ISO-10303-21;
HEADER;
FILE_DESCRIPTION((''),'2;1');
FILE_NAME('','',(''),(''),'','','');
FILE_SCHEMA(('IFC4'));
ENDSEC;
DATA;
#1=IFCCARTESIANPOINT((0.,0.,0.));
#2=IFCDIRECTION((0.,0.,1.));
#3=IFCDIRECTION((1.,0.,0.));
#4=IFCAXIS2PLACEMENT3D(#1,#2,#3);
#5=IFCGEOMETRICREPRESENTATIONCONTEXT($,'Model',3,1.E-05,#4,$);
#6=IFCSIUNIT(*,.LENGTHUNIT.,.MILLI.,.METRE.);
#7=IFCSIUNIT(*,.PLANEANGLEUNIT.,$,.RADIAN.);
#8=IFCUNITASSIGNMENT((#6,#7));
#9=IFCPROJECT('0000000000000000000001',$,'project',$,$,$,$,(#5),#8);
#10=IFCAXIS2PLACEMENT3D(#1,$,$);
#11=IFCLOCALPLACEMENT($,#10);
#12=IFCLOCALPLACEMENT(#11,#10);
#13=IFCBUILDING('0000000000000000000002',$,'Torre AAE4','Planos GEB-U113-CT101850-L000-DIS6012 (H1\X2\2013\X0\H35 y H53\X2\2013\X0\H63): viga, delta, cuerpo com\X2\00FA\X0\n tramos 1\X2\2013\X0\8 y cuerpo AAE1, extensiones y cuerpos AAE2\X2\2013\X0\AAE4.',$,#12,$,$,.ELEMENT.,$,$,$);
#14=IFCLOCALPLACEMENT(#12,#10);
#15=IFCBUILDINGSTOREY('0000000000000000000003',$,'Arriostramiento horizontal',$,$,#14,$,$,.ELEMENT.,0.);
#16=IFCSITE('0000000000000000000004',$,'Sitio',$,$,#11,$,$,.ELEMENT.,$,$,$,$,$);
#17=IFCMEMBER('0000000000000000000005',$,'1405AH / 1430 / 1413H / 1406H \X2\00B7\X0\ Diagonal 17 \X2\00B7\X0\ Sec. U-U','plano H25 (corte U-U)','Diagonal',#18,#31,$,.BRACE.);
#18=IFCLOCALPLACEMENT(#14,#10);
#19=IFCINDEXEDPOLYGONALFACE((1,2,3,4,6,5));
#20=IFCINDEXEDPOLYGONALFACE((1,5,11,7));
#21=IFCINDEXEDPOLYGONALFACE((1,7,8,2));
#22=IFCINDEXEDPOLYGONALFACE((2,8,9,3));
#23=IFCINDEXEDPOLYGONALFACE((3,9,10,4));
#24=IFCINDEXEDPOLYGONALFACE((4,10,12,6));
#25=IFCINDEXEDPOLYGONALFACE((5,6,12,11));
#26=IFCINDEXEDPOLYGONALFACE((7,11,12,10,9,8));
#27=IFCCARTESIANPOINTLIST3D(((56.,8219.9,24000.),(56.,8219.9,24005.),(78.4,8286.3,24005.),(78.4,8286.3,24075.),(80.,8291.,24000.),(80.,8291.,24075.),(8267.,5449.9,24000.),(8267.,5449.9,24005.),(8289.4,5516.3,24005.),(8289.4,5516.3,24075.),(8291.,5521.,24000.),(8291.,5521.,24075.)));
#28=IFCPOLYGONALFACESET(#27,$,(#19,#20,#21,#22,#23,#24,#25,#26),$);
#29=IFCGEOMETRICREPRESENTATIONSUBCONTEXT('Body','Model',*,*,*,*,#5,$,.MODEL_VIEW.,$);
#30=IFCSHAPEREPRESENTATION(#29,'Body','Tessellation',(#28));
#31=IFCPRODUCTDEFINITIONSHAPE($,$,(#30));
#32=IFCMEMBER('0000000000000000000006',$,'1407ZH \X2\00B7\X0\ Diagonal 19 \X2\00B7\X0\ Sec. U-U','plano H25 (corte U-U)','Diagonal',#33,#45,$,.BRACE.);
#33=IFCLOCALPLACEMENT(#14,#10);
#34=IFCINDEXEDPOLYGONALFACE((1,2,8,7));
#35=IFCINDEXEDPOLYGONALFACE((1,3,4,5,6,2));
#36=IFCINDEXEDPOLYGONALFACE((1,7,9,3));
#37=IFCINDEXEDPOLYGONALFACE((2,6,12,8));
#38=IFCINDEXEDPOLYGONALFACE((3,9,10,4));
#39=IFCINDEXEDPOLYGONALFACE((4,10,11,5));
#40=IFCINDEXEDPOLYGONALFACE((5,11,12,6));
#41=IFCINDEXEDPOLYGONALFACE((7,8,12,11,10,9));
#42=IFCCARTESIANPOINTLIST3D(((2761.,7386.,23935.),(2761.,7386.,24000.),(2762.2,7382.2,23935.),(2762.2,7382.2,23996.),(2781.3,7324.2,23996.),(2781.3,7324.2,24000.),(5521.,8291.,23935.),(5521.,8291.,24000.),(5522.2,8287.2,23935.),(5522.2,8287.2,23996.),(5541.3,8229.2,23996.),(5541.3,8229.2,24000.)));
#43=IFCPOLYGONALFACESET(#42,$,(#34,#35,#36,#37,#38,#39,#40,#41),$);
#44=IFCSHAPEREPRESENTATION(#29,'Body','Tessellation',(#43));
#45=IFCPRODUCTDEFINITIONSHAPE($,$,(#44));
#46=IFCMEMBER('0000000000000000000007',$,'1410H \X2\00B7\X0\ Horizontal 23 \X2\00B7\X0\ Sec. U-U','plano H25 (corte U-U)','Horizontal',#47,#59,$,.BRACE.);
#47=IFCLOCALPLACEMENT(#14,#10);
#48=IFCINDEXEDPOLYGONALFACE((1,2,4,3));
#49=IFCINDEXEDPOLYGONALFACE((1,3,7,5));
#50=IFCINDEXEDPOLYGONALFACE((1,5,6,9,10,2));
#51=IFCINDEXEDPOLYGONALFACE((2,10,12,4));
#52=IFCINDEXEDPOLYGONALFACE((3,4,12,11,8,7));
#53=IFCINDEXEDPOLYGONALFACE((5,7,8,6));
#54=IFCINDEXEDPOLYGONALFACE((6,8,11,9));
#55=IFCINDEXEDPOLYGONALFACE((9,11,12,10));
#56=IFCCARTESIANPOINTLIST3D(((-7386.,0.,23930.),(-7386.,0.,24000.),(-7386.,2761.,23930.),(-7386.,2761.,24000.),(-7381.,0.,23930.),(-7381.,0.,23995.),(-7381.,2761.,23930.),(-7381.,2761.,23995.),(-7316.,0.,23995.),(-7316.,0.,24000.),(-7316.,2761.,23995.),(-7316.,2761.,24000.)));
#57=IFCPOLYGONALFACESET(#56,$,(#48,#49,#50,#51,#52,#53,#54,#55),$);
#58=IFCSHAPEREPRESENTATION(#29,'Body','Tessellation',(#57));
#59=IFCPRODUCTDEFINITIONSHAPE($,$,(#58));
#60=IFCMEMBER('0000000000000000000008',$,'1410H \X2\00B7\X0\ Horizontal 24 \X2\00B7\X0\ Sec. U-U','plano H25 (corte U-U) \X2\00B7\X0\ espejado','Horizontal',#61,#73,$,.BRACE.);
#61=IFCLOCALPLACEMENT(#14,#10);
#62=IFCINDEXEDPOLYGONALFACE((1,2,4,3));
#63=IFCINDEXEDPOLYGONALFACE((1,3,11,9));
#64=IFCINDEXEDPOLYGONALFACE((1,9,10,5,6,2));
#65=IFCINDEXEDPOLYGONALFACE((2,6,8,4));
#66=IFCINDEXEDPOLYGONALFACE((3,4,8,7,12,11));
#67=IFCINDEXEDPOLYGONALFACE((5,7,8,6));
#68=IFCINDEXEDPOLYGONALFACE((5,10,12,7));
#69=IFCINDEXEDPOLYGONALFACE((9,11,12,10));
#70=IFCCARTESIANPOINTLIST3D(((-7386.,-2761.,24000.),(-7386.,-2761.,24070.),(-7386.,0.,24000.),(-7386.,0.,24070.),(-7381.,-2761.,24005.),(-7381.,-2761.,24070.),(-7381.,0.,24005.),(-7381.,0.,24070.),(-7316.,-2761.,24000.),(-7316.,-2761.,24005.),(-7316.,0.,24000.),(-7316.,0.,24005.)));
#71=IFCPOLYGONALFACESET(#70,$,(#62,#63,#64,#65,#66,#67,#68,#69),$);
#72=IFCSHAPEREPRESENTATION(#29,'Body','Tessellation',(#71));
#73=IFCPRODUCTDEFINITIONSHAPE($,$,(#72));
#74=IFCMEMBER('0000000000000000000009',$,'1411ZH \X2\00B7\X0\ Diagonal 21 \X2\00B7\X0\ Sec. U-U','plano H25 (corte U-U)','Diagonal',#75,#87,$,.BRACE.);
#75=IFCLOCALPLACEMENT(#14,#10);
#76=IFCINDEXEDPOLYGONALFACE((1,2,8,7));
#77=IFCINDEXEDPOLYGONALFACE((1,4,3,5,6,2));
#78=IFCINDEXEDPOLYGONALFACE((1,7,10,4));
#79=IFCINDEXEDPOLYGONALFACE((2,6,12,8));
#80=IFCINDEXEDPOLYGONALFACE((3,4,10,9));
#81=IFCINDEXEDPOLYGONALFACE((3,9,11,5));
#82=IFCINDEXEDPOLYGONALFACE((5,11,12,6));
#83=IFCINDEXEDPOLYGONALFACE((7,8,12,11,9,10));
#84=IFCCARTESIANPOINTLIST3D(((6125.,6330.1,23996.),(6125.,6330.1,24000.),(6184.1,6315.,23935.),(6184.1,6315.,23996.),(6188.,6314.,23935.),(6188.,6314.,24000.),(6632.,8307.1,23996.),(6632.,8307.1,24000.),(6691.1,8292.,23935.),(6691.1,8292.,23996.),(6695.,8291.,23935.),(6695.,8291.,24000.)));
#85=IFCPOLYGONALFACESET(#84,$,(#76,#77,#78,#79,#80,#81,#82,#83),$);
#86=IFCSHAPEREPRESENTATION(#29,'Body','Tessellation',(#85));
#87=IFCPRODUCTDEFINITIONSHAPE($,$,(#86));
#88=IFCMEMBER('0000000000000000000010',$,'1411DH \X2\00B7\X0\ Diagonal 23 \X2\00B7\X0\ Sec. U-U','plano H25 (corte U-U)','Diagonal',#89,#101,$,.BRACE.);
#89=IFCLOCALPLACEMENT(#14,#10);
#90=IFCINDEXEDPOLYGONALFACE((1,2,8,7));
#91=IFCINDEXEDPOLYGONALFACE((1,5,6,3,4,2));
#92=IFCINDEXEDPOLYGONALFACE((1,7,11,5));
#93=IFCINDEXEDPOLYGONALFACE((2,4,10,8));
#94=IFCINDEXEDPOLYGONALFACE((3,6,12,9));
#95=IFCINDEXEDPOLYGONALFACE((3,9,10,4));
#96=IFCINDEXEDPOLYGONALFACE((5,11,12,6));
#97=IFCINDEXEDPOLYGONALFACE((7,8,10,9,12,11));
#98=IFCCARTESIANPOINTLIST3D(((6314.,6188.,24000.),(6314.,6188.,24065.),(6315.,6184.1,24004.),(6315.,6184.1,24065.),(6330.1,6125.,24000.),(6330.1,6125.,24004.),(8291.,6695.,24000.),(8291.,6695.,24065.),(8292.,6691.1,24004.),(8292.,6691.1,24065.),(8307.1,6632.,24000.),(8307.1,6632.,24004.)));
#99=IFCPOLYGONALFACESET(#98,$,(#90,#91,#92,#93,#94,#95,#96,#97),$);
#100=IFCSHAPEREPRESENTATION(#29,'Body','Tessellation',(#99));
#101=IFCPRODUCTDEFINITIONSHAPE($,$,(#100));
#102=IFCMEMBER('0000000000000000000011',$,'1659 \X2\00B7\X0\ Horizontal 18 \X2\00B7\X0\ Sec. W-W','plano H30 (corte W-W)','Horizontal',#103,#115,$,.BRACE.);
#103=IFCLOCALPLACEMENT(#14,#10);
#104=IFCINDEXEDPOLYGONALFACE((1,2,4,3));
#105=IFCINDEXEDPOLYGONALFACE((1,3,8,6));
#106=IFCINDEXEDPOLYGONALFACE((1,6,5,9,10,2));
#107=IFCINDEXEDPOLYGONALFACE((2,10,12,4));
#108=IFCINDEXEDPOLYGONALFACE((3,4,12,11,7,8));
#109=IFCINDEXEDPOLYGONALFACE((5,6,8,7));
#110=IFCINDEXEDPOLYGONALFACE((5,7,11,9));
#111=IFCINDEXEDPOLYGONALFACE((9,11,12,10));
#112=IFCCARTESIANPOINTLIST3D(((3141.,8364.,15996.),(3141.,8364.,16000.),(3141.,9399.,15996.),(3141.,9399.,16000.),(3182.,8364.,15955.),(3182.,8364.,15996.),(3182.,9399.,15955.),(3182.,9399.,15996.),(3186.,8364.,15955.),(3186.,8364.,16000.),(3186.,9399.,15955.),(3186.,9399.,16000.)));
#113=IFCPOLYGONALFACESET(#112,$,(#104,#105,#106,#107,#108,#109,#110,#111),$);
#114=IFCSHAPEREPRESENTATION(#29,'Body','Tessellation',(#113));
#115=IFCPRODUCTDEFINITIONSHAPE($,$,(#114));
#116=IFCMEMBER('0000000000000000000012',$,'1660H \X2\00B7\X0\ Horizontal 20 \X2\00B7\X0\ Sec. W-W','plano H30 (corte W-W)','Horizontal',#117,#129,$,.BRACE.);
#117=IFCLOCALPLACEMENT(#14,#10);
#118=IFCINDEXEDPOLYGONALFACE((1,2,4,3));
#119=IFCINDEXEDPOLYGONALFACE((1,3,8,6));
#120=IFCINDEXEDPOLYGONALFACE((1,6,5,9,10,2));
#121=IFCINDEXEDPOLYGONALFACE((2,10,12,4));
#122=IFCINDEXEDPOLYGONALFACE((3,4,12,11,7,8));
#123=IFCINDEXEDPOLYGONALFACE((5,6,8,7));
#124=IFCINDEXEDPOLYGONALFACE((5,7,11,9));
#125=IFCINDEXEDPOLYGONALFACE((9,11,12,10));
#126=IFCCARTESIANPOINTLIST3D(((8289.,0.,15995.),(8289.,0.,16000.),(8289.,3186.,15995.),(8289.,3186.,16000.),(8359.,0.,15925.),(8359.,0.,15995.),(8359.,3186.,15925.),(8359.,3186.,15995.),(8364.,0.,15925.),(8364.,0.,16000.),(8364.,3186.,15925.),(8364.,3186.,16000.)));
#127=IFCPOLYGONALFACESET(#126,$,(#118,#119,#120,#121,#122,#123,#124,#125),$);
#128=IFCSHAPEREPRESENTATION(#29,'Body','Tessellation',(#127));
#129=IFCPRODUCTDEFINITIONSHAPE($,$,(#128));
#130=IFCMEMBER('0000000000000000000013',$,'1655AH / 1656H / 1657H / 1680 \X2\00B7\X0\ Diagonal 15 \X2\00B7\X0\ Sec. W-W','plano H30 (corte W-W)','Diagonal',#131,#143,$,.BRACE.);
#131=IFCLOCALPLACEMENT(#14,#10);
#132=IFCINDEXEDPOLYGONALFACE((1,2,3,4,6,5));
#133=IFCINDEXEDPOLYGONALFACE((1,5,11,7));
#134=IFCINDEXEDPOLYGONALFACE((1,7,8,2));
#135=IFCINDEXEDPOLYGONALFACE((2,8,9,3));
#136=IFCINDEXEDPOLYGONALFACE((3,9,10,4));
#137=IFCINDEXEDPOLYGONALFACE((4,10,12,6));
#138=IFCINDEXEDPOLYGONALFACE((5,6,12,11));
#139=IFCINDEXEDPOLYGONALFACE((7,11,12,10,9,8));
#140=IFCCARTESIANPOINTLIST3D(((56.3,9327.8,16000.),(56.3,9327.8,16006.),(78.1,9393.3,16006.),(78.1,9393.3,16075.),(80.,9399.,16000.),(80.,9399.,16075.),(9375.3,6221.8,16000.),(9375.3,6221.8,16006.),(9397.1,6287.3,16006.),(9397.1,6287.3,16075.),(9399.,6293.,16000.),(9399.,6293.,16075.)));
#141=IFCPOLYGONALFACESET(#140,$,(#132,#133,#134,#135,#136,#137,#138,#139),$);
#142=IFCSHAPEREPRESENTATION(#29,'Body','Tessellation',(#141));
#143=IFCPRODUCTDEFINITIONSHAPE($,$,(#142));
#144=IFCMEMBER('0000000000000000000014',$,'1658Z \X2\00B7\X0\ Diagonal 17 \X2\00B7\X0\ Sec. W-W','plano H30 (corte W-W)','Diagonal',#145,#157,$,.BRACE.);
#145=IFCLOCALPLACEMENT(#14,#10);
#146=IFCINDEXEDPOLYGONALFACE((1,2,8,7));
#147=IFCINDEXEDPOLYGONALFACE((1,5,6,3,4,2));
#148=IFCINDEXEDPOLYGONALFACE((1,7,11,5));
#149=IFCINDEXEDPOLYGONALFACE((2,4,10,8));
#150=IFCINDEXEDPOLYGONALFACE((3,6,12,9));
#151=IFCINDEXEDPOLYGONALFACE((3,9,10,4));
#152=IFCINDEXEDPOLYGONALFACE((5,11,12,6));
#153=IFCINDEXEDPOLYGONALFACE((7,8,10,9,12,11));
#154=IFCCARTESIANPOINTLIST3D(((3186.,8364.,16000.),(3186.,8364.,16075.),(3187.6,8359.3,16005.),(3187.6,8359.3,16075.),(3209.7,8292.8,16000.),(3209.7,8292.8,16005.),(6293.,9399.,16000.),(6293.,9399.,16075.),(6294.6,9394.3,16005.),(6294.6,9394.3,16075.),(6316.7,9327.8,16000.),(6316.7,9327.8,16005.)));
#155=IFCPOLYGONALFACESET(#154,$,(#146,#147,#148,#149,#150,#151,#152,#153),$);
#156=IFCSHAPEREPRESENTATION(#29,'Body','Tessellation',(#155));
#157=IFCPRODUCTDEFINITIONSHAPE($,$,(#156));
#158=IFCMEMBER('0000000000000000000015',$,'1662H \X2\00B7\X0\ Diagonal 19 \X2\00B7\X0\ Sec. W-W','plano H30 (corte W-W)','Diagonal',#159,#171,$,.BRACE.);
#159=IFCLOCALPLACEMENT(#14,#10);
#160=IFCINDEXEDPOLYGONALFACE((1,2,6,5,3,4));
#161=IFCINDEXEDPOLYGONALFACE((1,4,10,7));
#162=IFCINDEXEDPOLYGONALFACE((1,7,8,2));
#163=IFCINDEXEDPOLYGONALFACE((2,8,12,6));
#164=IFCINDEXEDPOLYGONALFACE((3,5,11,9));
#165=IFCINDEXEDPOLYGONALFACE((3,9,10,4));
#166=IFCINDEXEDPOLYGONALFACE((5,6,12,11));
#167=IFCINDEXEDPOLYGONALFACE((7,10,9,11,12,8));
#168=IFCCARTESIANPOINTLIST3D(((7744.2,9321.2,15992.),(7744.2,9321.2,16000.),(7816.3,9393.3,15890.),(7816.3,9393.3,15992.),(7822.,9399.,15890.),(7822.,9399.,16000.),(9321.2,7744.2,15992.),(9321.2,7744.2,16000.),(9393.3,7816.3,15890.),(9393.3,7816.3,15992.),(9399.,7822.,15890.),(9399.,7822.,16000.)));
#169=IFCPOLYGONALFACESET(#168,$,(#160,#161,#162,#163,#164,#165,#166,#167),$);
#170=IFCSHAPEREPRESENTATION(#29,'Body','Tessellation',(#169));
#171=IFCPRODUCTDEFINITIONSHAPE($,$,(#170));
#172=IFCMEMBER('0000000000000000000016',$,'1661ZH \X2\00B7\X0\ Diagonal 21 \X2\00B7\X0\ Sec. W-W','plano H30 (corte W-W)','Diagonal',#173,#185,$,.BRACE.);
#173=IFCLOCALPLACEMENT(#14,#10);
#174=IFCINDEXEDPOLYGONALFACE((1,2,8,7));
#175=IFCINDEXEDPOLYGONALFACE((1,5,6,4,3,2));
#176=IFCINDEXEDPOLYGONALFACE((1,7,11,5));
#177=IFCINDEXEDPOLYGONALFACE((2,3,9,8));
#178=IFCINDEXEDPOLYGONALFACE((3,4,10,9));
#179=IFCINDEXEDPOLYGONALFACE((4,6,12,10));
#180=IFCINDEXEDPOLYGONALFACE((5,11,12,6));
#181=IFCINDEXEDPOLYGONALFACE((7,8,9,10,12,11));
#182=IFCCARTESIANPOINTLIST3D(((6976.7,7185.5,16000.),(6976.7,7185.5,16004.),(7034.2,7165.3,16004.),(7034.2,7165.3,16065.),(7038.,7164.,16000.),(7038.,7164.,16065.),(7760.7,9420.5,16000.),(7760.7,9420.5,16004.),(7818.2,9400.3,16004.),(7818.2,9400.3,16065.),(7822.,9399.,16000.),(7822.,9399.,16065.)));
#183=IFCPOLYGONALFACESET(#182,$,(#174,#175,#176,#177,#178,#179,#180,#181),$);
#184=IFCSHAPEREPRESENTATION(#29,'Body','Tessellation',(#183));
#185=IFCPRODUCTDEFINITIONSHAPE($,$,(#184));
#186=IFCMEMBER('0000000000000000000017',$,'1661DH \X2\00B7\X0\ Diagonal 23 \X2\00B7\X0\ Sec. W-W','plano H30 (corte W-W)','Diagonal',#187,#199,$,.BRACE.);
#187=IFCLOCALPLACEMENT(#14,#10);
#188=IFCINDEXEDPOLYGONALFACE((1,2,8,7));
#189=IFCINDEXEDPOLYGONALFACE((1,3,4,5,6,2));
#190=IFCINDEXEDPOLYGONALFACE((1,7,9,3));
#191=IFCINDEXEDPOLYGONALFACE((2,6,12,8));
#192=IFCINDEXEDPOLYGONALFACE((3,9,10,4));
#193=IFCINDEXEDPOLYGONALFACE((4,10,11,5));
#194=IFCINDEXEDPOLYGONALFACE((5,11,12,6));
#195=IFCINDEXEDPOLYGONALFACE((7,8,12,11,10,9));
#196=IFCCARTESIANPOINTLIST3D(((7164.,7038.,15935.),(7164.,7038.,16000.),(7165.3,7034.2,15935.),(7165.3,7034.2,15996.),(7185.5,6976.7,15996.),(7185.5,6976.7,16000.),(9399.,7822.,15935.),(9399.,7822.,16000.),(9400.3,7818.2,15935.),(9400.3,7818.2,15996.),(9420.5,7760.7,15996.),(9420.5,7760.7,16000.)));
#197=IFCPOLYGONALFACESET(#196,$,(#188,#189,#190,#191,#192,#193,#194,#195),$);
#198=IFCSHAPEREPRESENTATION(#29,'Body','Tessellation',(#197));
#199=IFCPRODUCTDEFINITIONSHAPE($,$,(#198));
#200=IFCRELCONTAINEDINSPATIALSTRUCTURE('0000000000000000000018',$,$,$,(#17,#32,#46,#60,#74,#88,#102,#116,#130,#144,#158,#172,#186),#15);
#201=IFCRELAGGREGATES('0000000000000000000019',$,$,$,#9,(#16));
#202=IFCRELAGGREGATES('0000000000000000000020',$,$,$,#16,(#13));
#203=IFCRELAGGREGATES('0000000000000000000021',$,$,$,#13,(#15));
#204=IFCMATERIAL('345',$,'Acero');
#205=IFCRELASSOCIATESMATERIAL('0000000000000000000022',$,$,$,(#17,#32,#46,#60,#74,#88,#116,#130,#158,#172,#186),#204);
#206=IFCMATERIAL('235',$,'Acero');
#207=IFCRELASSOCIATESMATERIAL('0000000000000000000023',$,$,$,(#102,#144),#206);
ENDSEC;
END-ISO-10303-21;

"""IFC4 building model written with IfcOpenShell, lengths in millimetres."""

from ifc_helpers import new_model, si_unit, frame, frame_2d, origin, origin_with_axes, place, context, subcontext, project, spatial, l_section, extrude, material, element, save


model = new_model("IFC4")

# Units and contexts
model_context = context("Model", 3, precision=1e-05, world=origin_with_axes())
body_context = subcontext(model_context, "Body", "Model", "MODEL_VIEW")
ifc_project = project(units=[si_unit("LENGTHUNIT", "METRE", prefix="MILLI"), si_unit("PLANEANGLEUNIT", "RADIAN")], contexts=[model_context])

# Site, building, storey
site_placement = place(None, origin())
site = spatial("IfcSite", under=ifc_project, at=site_placement, Name="Sitio", CompositionType="ELEMENT")
building_placement = place(site_placement, origin())
building = spatial("IfcBuilding", under=site, at=building_placement, Name="Torre AAE4", Description="Planos GEB-U113-CT101850-L000-DIS6012 (H1–H35 y H53–H63): viga, delta, cuerpo común tramos 1–8 y cuerpo AAE1, extensiones y cuerpos AAE2–AAE4.", CompositionType="ELEMENT")
storey_placement = place(building_placement, origin())
storey = spatial("IfcBuildingStorey", under=building, at=storey_placement, Name="Arriostramiento horizontal", CompositionType="ELEMENT", Elevation=0.0)

# Members
ifc_material_1 = material(Name="235", Category="Acero")
ifc_material_2 = material(Name="345", Category="Acero")
member_1_placement = place(storey_placement, frame((8291.0, 5521.0, 24000.0), z_axis=(-0.947535, 0.319653, 0.0), x_axis=(-0.319653, -0.947535, 0.0)))
element("IfcMember", 1, at=member_1_placement, inside=storey, material=ifc_material_2, Name="1405AH / 1430 / 1413H / 1406H · Diagonal 17 · Sec. U-U", Description="plano H25 (corte U-U)", ObjectType="Diagonal", PredefinedType="BRACE", context=body_context, shape_type="SweptSolid", body=[
    extrude(l_section(Depth=75.0, Width=75.0, Thickness=5.0, at=frame_2d((37.5, 37.5))), None, (0.0, 0.0, 1.0), 8665.6),
])
member_2_placement = place(storey_placement, frame((2761.0, 7386.0, 24000.0), z_axis=(0.950221, 0.311576, 0.0), x_axis=(0.311576, -0.950221, 0.0)))
element("IfcMember", 2, at=member_2_placement, inside=storey, material=ifc_material_2, Name="1407ZH · Diagonal 19 · Sec. U-U", Description="plano H25 (corte U-U)", ObjectType="Diagonal", PredefinedType="BRACE", context=body_context, shape_type="SweptSolid", body=[
    extrude(l_section(Depth=65.0, Width=65.0, Thickness=4.0, at=frame_2d((32.5, 32.5))), None, (0.0, 0.0, 1.0), 2904.6),
])
for number, where, z_axis, x_axis, name, description in (
    (3, (-7386.0, 0.0, 24000.0), (0.0, 1.0, 0.0), (1.0, 0.0, 0.0), "1410H · Horizontal 23 · Sec. U-U", "plano H25 (corte U-U)"),
    (4, (-7386.0, 0.0, 24000.0), (0.0, -1.0, 0.0), (1.0, 0.0, 0.0), "1410H · Horizontal 24 · Sec. U-U", "plano H25 (corte U-U) · espejado"),
):
    element("IfcMember", number, at=place(storey_placement, frame(where, z_axis=z_axis, x_axis=x_axis)), inside=storey, material=ifc_material_2, Name=name, Description=description, ObjectType="Horizontal", PredefinedType="BRACE", context=body_context, shape_type="SweptSolid", body=[
        extrude(l_section(Depth=70.0, Width=70.0, Thickness=5.0, at=frame_2d((35.0, 35.0))), None, (0.0, 0.0, 1.0), 2761.0),
    ])
for number, where, z_axis, x_axis, name in (
    (5, (6695.0, 8291.0, 24000.0), (-0.248411, -0.968655, 0.0), (-0.968655, 0.248411, 0.0), "1411ZH · Diagonal 21 · Sec. U-U"),
    (6, (8291.0, 6695.0, 24000.0), (-0.968655, -0.248411, 0.0), (0.248411, -0.968655, 0.0), "1411DH · Diagonal 23 · Sec. U-U"),
):
    element("IfcMember", number, at=place(storey_placement, frame(where, z_axis=z_axis, x_axis=x_axis)), inside=storey, material=ifc_material_2, Name=name, Description="plano H25 (corte U-U)", ObjectType="Diagonal", PredefinedType="BRACE", context=body_context, shape_type="SweptSolid", body=[
        extrude(l_section(Depth=65.0, Width=65.0, Thickness=4.0, at=frame_2d((32.5, 32.5))), None, (0.0, 0.0, 1.0), 2041.0),
    ])
member_3_placement = place(storey_placement, frame((3186.0, 9399.0, 16000.0), z_axis=(0.0, -1.0, 0.0), x_axis=(-1.0, 0.0, 0.0)))
element("IfcMember", 7, at=member_3_placement, inside=storey, material=ifc_material_1, Name="1659 · Horizontal 18 · Sec. W-W", Description="plano H30 (corte W-W)", ObjectType="Horizontal", PredefinedType="BRACE", context=body_context, shape_type="SweptSolid", body=[
    extrude(l_section(Depth=45.0, Width=45.0, Thickness=4.0, at=frame_2d((22.5, 22.5))), None, (0.0, 0.0, 1.0), 1035.0),
])
member_4_placement = place(storey_placement, frame((8364.0, 3186.0, 16000.0), z_axis=(0.0, -1.0, 0.0), x_axis=(-1.0, 0.0, 0.0)))
element("IfcMember", 8, at=member_4_placement, inside=storey, material=ifc_material_2, Name="1660H · Horizontal 20 · Sec. W-W", Description="plano H30 (corte W-W)", ObjectType="Horizontal", PredefinedType="BRACE", context=body_context, shape_type="SweptSolid", body=[
    extrude(l_section(Depth=75.0, Width=75.0, Thickness=5.0, at=frame_2d((37.5, 37.5))), None, (0.0, 0.0, 1.0), 3186.0),
])
member_5_placement = place(storey_placement, frame((9399.0, 6293.0, 16000.0), z_axis=(-0.948693, 0.316197, 0.0), x_axis=(-0.316197, -0.948693, 0.0)))
element("IfcMember", 9, at=member_5_placement, inside=storey, material=ifc_material_2, Name="1655AH / 1656H / 1657H / 1680 · Diagonal 15 · Sec. W-W", Description="plano H30 (corte W-W)", ObjectType="Diagonal", PredefinedType="BRACE", context=body_context, shape_type="SweptSolid", body=[
    extrude(l_section(Depth=75.0, Width=75.0, Thickness=6.0, at=frame_2d((37.5, 37.5))), None, (0.0, 0.0, 1.0), 9823.0),
])
member_6_placement = place(storey_placement, frame((6293.0, 9399.0, 16000.0), z_axis=(-0.948744, -0.316045, 0.0), x_axis=(0.316045, -0.948744, 0.0)))
element("IfcMember", 10, at=member_6_placement, inside=storey, material=ifc_material_1, Name="1658Z · Diagonal 17 · Sec. W-W", Description="plano H30 (corte W-W)", ObjectType="Diagonal", PredefinedType="BRACE", context=body_context, shape_type="SweptSolid", body=[
    extrude(l_section(Depth=75.0, Width=75.0, Thickness=5.0, at=frame_2d((37.5, 37.5))), None, (0.0, 0.0, 1.0), 3274.9),
])
member_7_placement = place(storey_placement, frame((7822.0, 9399.0, 16000.0), z_axis=(0.707107, -0.707107, 0.0), x_axis=(-0.707107, -0.707107, 0.0)))
element("IfcMember", 11, at=member_7_placement, inside=storey, material=ifc_material_2, Name="1662H · Diagonal 19 · Sec. W-W", Description="plano H30 (corte W-W)", ObjectType="Diagonal", PredefinedType="BRACE", context=body_context, shape_type="SweptSolid", body=[
    extrude(l_section(Depth=110.0, Width=110.0, Thickness=8.0, at=frame_2d((55.0, 55.0))), None, (0.0, 0.0, 1.0), 2230.2),
])
for number, where, z_axis, x_axis, name in (
    (12, (7038.0, 7164.0, 16000.0), (0.331009, 0.943628, 0.0), (-0.943628, 0.331009, 0.0), "1661ZH · Diagonal 21 · Sec. W-W"),
    (13, (7164.0, 7038.0, 16000.0), (0.943628, 0.331009, 0.0), (0.331009, -0.943628, 0.0), "1661DH · Diagonal 23 · Sec. W-W"),
):
    element("IfcMember", number, at=place(storey_placement, frame(where, z_axis=z_axis, x_axis=x_axis)), inside=storey, material=ifc_material_2, Name=name, Description="plano H30 (corte W-W)", ObjectType="Diagonal", PredefinedType="BRACE", context=body_context, shape_type="SweptSolid", body=[
        extrude(l_section(Depth=65.0, Width=65.0, Thickness=4.0, at=frame_2d((32.5, 32.5))), None, (0.0, 0.0, 1.0), 2368.5),
    ])

save(model, "model.ifc")
